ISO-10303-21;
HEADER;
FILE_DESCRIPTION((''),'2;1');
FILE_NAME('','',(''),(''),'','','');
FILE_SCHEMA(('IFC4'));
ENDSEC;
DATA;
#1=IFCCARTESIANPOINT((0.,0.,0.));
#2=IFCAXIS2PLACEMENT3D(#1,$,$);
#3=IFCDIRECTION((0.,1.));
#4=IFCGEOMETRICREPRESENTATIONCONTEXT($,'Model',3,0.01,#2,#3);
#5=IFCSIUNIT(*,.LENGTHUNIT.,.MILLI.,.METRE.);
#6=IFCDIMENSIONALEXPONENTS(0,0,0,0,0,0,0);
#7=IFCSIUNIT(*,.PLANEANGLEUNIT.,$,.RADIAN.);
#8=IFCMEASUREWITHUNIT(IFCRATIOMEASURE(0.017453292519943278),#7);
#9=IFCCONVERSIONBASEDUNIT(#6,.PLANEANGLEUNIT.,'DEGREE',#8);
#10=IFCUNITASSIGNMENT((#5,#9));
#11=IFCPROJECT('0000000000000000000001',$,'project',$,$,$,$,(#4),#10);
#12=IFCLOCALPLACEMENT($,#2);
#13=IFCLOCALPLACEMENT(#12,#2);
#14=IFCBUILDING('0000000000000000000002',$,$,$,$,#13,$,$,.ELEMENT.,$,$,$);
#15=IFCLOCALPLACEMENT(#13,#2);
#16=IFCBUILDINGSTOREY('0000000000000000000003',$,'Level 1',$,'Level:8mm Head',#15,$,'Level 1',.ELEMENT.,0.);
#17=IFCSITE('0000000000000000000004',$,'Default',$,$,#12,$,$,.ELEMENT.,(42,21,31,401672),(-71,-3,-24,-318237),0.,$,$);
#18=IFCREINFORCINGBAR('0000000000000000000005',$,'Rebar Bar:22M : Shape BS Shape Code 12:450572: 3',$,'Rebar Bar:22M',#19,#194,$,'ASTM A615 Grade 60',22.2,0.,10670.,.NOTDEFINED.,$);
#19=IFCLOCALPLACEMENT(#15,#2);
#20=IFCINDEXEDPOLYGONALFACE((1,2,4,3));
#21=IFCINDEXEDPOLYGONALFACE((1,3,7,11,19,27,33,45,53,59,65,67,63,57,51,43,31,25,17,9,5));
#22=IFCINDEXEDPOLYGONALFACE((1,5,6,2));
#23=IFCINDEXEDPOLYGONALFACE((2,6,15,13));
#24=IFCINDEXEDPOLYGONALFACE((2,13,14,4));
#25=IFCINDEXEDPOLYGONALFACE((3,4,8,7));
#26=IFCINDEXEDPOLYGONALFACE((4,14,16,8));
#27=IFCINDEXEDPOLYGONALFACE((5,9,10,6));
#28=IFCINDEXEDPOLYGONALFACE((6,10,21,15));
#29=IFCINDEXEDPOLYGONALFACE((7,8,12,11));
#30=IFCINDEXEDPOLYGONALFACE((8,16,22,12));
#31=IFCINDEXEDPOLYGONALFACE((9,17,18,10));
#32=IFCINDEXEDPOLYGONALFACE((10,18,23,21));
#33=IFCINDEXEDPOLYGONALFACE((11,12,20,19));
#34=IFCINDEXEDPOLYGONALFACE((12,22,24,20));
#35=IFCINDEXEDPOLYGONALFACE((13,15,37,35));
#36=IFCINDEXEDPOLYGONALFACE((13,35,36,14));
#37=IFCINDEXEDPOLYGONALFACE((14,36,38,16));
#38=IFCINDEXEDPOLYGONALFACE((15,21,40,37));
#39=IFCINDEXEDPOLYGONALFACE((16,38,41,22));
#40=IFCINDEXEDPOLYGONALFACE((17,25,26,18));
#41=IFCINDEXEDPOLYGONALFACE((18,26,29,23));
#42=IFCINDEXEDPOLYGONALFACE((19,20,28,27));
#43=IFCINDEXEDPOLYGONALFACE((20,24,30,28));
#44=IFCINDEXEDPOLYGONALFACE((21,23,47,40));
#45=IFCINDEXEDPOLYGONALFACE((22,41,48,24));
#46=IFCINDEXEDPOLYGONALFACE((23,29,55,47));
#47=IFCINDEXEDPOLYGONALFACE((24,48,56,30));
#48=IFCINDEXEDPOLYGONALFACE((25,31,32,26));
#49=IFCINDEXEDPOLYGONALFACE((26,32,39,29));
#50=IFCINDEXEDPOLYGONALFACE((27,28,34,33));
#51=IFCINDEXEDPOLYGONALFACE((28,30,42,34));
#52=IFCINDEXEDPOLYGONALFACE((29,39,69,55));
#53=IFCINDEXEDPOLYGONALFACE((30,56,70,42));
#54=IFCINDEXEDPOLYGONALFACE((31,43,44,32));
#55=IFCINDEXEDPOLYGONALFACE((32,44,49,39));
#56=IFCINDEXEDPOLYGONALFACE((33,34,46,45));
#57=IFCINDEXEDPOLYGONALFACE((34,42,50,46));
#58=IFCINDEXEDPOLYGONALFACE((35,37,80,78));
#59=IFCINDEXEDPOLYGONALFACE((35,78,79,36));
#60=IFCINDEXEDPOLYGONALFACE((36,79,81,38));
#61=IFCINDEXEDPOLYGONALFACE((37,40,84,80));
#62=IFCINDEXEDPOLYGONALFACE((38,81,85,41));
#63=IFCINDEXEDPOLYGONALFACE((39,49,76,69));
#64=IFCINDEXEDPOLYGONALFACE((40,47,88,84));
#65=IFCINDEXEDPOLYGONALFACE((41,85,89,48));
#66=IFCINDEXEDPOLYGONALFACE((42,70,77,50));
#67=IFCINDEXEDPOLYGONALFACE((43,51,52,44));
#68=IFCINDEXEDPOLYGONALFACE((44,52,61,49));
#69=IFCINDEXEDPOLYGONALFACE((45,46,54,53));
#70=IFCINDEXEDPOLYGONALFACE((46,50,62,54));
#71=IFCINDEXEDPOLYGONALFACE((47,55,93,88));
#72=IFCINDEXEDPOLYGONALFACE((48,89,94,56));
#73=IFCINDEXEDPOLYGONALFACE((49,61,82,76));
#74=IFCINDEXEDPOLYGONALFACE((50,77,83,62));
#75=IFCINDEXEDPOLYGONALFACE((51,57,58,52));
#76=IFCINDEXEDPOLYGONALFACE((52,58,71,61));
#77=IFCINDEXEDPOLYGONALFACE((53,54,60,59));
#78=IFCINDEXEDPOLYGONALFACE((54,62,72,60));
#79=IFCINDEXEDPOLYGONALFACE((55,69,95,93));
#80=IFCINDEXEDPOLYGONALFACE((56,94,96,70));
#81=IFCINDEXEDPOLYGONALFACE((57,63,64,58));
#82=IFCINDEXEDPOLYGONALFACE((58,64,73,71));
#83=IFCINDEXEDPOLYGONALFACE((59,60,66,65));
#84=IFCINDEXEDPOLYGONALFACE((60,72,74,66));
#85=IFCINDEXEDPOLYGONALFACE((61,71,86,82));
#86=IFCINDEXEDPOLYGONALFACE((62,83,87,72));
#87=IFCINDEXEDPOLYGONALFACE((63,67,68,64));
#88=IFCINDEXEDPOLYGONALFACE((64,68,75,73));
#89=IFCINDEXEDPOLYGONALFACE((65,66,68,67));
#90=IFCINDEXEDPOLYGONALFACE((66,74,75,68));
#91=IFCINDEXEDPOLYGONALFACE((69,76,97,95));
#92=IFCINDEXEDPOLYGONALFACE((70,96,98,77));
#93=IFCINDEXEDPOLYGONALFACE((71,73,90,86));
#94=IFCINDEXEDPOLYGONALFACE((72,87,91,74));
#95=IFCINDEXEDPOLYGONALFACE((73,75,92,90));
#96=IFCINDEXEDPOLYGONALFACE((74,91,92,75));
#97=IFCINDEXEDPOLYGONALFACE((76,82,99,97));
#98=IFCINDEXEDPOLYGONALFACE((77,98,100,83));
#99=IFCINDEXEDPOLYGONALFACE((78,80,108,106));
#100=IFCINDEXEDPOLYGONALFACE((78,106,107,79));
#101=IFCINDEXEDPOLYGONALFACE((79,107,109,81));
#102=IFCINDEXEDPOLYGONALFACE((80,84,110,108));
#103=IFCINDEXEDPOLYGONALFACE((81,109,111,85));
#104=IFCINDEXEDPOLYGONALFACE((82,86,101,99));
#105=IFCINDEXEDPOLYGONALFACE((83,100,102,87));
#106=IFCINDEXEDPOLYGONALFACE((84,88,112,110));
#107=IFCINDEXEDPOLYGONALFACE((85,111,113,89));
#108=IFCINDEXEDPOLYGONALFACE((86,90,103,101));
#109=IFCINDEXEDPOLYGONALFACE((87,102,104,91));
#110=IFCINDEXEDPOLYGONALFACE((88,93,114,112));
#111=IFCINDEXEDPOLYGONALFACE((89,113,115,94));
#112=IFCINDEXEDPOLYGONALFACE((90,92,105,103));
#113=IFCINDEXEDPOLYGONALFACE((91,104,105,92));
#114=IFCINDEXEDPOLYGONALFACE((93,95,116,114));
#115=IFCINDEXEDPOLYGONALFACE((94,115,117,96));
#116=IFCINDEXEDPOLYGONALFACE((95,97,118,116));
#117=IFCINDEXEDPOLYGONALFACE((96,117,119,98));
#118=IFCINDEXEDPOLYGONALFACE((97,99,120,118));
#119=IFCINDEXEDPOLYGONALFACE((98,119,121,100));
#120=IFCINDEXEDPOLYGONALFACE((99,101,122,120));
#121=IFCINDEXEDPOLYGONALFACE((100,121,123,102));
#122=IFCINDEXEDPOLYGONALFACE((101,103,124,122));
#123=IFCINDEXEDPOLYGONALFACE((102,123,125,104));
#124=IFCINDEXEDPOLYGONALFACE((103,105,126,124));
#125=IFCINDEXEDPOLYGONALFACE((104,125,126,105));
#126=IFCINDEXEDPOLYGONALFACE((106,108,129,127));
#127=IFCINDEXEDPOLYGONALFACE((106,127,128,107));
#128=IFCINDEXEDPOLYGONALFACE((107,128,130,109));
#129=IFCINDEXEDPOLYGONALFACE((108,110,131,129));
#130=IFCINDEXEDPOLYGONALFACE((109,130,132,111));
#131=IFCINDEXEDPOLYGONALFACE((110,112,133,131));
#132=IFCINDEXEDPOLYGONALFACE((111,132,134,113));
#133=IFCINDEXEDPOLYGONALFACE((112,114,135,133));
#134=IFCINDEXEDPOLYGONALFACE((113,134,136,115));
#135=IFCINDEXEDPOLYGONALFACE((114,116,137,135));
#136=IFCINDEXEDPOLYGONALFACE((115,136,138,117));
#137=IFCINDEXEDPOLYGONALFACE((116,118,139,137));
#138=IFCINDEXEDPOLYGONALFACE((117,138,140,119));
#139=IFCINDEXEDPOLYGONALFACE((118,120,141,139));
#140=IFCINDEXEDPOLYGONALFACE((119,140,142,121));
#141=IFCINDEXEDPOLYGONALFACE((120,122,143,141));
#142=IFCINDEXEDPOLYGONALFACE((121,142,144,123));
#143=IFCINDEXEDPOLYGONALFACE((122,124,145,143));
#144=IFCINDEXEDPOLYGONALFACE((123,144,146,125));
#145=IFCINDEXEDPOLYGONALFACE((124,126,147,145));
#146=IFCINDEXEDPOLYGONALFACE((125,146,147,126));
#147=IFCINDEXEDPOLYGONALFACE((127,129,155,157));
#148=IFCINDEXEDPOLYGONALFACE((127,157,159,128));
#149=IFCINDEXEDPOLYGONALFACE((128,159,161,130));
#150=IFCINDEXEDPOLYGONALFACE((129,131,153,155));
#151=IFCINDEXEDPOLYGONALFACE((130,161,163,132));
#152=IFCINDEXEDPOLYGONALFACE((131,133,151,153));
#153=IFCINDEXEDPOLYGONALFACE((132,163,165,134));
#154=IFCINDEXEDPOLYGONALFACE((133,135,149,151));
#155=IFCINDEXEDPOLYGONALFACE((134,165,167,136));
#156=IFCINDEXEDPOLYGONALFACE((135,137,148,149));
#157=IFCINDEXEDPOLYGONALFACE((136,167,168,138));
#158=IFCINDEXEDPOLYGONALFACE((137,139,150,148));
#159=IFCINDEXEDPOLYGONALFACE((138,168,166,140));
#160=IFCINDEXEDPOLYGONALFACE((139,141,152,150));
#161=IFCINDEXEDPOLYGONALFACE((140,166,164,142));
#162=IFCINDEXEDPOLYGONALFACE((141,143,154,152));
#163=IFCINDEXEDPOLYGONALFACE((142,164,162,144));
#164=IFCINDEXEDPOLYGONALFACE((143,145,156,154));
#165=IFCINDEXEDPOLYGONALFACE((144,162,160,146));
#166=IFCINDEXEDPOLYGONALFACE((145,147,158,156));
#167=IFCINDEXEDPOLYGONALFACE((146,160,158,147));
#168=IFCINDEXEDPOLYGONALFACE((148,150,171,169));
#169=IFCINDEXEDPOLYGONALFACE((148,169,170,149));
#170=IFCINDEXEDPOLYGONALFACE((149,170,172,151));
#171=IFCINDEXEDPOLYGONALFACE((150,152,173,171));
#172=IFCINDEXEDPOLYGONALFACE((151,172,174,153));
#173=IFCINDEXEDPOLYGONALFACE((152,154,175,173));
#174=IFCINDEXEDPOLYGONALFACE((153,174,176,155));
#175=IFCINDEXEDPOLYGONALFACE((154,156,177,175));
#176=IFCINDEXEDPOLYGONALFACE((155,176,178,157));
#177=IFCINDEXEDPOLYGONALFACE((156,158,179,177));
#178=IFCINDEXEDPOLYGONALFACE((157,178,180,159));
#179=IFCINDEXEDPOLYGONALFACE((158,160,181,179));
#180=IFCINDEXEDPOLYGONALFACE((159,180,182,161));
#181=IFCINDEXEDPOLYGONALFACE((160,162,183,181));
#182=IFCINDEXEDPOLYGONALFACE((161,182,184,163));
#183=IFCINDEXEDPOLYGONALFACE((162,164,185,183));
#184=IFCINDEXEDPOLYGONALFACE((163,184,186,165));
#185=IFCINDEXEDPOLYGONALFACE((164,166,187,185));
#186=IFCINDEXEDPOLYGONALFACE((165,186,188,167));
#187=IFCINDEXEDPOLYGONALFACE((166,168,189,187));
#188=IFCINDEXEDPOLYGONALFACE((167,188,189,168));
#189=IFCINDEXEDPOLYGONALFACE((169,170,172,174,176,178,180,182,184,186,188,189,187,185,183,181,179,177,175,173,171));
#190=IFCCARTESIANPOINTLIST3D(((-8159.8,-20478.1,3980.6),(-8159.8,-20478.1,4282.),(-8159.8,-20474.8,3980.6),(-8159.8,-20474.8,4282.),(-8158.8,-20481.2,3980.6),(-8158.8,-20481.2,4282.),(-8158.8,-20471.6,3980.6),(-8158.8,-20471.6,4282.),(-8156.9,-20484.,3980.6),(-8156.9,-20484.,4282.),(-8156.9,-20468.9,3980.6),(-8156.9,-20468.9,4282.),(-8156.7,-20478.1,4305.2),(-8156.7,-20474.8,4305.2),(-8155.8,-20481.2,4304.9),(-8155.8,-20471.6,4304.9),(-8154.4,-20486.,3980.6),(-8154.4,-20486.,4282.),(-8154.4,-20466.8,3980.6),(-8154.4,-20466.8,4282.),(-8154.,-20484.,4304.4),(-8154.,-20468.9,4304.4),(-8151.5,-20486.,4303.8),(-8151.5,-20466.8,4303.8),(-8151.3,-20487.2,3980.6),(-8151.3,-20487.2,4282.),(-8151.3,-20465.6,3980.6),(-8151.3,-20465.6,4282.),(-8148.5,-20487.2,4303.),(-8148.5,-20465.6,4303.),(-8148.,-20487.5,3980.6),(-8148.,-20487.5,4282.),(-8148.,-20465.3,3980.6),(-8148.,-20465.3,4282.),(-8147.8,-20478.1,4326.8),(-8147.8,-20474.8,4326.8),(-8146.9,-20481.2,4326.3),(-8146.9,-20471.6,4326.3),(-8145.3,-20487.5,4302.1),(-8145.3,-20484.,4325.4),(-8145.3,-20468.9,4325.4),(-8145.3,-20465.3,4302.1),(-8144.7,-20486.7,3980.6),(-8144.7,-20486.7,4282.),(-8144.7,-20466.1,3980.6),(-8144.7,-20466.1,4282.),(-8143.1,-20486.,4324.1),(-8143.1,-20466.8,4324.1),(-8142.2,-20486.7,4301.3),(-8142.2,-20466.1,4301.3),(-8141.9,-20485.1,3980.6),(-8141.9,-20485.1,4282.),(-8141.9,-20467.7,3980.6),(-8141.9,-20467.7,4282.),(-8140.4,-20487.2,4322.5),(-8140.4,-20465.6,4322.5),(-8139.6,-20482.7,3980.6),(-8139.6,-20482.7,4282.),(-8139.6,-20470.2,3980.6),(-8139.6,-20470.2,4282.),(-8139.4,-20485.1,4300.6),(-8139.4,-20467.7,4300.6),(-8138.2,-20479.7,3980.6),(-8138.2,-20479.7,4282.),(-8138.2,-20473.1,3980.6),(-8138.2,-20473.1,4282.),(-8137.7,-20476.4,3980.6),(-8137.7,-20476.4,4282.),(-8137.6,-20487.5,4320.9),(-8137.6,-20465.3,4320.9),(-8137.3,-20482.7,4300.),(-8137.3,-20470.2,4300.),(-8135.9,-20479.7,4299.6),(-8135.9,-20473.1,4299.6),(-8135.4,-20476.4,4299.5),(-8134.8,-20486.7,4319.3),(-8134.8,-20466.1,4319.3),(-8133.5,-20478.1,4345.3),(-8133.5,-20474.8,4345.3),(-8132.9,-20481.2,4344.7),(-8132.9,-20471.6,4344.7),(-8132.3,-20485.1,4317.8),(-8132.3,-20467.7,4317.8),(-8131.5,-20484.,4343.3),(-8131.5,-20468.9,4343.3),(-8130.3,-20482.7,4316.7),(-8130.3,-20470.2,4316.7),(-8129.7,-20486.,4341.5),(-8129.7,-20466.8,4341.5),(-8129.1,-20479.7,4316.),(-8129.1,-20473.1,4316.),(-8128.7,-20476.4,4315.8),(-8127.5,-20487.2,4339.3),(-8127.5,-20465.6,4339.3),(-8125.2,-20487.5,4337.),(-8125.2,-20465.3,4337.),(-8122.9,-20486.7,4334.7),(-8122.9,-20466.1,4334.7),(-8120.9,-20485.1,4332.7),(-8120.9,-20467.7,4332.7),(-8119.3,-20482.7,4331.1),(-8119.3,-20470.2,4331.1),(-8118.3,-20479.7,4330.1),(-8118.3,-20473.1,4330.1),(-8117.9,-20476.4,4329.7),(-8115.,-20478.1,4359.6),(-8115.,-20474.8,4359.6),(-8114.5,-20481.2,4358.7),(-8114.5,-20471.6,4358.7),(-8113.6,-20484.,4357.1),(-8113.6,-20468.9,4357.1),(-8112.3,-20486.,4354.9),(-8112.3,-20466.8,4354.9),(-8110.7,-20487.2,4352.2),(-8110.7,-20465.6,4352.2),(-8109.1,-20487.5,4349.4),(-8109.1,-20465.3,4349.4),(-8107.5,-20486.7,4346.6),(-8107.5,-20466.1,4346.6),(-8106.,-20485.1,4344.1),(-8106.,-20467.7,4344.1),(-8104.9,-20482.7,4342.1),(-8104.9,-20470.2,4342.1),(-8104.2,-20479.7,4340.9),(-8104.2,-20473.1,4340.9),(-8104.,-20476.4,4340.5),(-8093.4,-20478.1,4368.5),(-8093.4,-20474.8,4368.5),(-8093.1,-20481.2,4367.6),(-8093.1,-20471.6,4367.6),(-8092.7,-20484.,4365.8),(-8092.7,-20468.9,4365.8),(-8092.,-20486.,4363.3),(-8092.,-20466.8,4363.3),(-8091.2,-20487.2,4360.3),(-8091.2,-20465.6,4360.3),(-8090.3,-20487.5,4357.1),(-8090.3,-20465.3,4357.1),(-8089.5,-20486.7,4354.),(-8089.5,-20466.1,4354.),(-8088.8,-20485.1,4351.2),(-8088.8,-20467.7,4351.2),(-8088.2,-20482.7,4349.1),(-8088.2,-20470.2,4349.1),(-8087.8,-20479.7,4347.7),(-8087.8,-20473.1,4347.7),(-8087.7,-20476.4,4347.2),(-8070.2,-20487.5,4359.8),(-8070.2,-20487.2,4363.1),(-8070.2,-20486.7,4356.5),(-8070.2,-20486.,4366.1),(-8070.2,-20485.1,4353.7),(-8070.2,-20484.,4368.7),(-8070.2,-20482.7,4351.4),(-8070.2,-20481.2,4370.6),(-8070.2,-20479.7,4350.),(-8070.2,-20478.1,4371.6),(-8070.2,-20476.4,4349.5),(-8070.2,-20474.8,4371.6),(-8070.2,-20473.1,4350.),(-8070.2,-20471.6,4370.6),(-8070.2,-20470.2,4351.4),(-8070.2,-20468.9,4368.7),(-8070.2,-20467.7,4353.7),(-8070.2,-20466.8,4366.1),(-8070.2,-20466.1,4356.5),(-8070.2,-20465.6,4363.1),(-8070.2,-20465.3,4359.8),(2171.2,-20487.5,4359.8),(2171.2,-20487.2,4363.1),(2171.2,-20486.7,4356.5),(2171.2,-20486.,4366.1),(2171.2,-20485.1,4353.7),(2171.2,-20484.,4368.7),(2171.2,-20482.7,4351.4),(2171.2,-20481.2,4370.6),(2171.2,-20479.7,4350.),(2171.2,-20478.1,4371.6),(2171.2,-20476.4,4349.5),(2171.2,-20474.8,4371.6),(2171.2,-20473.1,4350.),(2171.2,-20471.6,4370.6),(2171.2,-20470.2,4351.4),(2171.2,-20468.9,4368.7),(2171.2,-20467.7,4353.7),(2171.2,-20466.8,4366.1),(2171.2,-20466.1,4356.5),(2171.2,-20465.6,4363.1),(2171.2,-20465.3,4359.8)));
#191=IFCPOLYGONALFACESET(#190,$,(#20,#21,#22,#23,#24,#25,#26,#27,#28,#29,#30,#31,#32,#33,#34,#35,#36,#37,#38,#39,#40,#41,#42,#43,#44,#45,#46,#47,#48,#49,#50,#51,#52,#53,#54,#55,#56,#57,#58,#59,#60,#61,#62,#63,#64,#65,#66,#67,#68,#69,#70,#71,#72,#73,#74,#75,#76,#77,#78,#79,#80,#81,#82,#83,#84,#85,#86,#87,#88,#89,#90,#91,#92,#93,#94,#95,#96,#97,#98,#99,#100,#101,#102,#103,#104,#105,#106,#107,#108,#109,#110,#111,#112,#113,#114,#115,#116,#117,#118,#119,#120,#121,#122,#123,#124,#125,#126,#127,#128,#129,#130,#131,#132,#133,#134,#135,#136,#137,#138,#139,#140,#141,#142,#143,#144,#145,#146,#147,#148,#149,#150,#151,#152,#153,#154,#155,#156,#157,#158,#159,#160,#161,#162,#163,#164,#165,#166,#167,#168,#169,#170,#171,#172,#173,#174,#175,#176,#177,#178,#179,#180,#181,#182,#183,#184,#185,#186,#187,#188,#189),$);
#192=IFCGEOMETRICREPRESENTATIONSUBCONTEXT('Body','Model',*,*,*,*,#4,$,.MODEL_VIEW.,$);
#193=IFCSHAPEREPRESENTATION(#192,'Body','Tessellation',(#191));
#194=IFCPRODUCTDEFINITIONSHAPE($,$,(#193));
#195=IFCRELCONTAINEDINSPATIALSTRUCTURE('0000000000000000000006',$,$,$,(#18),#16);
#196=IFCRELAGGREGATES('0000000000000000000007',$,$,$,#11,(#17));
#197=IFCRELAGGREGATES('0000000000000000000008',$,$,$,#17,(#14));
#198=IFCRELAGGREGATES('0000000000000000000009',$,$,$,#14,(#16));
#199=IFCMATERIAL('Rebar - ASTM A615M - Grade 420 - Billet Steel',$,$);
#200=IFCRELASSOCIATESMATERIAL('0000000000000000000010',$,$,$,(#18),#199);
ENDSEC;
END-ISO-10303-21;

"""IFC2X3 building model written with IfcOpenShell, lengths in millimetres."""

from ifc_helpers import new_model, entity, si_unit, converted_unit, direction, origin, place, context, subcontext, project, spatial, material, element, save


model = new_model("IFC2X3")

# Units and contexts
model_context = context("Model", 3, precision=0.01, world=origin(), true_north=direction((0.0, 1.0)))
body_context = subcontext(model_context, "Body", "Model", "MODEL_VIEW")
ifc_project = project(units=[si_unit("LENGTHUNIT", "METRE", prefix="MILLI"), converted_unit("PLANEANGLEUNIT", "DEGREE", entity("IfcRatioMeasure", 0.017453292519943278), si_unit("PLANEANGLEUNIT", "RADIAN"), dimensions=[0, 0, 0, 0, 0, 0, 0])], contexts=[model_context])

# Site, building, storey
site_placement = place(None, origin())
site = spatial("IfcSite", under=ifc_project, at=site_placement, Name="Default", CompositionType="ELEMENT", RefLatitude=(42, 21, 31, 401672), RefLongitude=(-71, -3, -24, -318237), RefElevation=0.0)
building_placement = place(site_placement, origin())
building = spatial("IfcBuilding", under=site, at=building_placement, CompositionType="ELEMENT")
storey_placement = place(building_placement, origin())
storey = spatial("IfcBuildingStorey", under=building, at=storey_placement, Name="Level 1", ObjectType="Level:8mm Head", LongName="Level 1", CompositionType="ELEMENT", Elevation=0.0)

# Reinforcing bar
ifc_material = material(Name="Rebar - ASTM A615M - Grade 420 - Billet Steel")
reinforcing_bar_1_placement = place(storey_placement, origin())
element("IfcReinforcingBar", 1, at=reinforcing_bar_1_placement, inside=storey, material=ifc_material, Name="Rebar Bar:22M : Shape BS Shape Code 12:450572: 3", SteelGrade="ASTM A615 Grade 60", ObjectType="Rebar Bar:22M", BarLength=10670.0, BarRole="NOTDEFINED", CrossSectionArea=0.0, NominalDiameter=22.2, context=body_context, shape_type="AdvancedSweptSolid", body=[
    entity("IfcSweptDiskSolid", entity("IfcCompositeCurve", [entity("IfcCompositeCurveSegment", "CONTINUOUS", True, entity("IfcPolyline", [entity("IfcCartesianPoint", [2171.2, -20476.4, 4360.6]), entity("IfcCartesianPoint", [-8070.2, -20476.4, 4360.6])])), entity("IfcCompositeCurveSegment", "CONTINUOUS", True, entity("IfcTrimmedCurve", entity("IfcCircle", entity("IfcAxis2Placement3D", entity("IfcCartesianPoint", [-8070.2, -20476.4, 4282.0]), entity("IfcDirection", [0.0, -1.0, 0.0]), entity("IfcDirection", [-1.0, 0.0, 0.0])), 78.6), [entity("IfcParameterValue", 270.0)], [entity("IfcParameterValue", 360.0)], True, "PARAMETER")), entity("IfcCompositeCurveSegment", "CONTINUOUS", True, entity("IfcPolyline", [entity("IfcCartesianPoint", [-8148.8, -20476.4, 4282.0]), entity("IfcCartesianPoint", [-8148.8, -20476.4, 3980.6])]))], False), 11.1, None, 0.0, 92.0),
])

save(model, "model.ifc")
